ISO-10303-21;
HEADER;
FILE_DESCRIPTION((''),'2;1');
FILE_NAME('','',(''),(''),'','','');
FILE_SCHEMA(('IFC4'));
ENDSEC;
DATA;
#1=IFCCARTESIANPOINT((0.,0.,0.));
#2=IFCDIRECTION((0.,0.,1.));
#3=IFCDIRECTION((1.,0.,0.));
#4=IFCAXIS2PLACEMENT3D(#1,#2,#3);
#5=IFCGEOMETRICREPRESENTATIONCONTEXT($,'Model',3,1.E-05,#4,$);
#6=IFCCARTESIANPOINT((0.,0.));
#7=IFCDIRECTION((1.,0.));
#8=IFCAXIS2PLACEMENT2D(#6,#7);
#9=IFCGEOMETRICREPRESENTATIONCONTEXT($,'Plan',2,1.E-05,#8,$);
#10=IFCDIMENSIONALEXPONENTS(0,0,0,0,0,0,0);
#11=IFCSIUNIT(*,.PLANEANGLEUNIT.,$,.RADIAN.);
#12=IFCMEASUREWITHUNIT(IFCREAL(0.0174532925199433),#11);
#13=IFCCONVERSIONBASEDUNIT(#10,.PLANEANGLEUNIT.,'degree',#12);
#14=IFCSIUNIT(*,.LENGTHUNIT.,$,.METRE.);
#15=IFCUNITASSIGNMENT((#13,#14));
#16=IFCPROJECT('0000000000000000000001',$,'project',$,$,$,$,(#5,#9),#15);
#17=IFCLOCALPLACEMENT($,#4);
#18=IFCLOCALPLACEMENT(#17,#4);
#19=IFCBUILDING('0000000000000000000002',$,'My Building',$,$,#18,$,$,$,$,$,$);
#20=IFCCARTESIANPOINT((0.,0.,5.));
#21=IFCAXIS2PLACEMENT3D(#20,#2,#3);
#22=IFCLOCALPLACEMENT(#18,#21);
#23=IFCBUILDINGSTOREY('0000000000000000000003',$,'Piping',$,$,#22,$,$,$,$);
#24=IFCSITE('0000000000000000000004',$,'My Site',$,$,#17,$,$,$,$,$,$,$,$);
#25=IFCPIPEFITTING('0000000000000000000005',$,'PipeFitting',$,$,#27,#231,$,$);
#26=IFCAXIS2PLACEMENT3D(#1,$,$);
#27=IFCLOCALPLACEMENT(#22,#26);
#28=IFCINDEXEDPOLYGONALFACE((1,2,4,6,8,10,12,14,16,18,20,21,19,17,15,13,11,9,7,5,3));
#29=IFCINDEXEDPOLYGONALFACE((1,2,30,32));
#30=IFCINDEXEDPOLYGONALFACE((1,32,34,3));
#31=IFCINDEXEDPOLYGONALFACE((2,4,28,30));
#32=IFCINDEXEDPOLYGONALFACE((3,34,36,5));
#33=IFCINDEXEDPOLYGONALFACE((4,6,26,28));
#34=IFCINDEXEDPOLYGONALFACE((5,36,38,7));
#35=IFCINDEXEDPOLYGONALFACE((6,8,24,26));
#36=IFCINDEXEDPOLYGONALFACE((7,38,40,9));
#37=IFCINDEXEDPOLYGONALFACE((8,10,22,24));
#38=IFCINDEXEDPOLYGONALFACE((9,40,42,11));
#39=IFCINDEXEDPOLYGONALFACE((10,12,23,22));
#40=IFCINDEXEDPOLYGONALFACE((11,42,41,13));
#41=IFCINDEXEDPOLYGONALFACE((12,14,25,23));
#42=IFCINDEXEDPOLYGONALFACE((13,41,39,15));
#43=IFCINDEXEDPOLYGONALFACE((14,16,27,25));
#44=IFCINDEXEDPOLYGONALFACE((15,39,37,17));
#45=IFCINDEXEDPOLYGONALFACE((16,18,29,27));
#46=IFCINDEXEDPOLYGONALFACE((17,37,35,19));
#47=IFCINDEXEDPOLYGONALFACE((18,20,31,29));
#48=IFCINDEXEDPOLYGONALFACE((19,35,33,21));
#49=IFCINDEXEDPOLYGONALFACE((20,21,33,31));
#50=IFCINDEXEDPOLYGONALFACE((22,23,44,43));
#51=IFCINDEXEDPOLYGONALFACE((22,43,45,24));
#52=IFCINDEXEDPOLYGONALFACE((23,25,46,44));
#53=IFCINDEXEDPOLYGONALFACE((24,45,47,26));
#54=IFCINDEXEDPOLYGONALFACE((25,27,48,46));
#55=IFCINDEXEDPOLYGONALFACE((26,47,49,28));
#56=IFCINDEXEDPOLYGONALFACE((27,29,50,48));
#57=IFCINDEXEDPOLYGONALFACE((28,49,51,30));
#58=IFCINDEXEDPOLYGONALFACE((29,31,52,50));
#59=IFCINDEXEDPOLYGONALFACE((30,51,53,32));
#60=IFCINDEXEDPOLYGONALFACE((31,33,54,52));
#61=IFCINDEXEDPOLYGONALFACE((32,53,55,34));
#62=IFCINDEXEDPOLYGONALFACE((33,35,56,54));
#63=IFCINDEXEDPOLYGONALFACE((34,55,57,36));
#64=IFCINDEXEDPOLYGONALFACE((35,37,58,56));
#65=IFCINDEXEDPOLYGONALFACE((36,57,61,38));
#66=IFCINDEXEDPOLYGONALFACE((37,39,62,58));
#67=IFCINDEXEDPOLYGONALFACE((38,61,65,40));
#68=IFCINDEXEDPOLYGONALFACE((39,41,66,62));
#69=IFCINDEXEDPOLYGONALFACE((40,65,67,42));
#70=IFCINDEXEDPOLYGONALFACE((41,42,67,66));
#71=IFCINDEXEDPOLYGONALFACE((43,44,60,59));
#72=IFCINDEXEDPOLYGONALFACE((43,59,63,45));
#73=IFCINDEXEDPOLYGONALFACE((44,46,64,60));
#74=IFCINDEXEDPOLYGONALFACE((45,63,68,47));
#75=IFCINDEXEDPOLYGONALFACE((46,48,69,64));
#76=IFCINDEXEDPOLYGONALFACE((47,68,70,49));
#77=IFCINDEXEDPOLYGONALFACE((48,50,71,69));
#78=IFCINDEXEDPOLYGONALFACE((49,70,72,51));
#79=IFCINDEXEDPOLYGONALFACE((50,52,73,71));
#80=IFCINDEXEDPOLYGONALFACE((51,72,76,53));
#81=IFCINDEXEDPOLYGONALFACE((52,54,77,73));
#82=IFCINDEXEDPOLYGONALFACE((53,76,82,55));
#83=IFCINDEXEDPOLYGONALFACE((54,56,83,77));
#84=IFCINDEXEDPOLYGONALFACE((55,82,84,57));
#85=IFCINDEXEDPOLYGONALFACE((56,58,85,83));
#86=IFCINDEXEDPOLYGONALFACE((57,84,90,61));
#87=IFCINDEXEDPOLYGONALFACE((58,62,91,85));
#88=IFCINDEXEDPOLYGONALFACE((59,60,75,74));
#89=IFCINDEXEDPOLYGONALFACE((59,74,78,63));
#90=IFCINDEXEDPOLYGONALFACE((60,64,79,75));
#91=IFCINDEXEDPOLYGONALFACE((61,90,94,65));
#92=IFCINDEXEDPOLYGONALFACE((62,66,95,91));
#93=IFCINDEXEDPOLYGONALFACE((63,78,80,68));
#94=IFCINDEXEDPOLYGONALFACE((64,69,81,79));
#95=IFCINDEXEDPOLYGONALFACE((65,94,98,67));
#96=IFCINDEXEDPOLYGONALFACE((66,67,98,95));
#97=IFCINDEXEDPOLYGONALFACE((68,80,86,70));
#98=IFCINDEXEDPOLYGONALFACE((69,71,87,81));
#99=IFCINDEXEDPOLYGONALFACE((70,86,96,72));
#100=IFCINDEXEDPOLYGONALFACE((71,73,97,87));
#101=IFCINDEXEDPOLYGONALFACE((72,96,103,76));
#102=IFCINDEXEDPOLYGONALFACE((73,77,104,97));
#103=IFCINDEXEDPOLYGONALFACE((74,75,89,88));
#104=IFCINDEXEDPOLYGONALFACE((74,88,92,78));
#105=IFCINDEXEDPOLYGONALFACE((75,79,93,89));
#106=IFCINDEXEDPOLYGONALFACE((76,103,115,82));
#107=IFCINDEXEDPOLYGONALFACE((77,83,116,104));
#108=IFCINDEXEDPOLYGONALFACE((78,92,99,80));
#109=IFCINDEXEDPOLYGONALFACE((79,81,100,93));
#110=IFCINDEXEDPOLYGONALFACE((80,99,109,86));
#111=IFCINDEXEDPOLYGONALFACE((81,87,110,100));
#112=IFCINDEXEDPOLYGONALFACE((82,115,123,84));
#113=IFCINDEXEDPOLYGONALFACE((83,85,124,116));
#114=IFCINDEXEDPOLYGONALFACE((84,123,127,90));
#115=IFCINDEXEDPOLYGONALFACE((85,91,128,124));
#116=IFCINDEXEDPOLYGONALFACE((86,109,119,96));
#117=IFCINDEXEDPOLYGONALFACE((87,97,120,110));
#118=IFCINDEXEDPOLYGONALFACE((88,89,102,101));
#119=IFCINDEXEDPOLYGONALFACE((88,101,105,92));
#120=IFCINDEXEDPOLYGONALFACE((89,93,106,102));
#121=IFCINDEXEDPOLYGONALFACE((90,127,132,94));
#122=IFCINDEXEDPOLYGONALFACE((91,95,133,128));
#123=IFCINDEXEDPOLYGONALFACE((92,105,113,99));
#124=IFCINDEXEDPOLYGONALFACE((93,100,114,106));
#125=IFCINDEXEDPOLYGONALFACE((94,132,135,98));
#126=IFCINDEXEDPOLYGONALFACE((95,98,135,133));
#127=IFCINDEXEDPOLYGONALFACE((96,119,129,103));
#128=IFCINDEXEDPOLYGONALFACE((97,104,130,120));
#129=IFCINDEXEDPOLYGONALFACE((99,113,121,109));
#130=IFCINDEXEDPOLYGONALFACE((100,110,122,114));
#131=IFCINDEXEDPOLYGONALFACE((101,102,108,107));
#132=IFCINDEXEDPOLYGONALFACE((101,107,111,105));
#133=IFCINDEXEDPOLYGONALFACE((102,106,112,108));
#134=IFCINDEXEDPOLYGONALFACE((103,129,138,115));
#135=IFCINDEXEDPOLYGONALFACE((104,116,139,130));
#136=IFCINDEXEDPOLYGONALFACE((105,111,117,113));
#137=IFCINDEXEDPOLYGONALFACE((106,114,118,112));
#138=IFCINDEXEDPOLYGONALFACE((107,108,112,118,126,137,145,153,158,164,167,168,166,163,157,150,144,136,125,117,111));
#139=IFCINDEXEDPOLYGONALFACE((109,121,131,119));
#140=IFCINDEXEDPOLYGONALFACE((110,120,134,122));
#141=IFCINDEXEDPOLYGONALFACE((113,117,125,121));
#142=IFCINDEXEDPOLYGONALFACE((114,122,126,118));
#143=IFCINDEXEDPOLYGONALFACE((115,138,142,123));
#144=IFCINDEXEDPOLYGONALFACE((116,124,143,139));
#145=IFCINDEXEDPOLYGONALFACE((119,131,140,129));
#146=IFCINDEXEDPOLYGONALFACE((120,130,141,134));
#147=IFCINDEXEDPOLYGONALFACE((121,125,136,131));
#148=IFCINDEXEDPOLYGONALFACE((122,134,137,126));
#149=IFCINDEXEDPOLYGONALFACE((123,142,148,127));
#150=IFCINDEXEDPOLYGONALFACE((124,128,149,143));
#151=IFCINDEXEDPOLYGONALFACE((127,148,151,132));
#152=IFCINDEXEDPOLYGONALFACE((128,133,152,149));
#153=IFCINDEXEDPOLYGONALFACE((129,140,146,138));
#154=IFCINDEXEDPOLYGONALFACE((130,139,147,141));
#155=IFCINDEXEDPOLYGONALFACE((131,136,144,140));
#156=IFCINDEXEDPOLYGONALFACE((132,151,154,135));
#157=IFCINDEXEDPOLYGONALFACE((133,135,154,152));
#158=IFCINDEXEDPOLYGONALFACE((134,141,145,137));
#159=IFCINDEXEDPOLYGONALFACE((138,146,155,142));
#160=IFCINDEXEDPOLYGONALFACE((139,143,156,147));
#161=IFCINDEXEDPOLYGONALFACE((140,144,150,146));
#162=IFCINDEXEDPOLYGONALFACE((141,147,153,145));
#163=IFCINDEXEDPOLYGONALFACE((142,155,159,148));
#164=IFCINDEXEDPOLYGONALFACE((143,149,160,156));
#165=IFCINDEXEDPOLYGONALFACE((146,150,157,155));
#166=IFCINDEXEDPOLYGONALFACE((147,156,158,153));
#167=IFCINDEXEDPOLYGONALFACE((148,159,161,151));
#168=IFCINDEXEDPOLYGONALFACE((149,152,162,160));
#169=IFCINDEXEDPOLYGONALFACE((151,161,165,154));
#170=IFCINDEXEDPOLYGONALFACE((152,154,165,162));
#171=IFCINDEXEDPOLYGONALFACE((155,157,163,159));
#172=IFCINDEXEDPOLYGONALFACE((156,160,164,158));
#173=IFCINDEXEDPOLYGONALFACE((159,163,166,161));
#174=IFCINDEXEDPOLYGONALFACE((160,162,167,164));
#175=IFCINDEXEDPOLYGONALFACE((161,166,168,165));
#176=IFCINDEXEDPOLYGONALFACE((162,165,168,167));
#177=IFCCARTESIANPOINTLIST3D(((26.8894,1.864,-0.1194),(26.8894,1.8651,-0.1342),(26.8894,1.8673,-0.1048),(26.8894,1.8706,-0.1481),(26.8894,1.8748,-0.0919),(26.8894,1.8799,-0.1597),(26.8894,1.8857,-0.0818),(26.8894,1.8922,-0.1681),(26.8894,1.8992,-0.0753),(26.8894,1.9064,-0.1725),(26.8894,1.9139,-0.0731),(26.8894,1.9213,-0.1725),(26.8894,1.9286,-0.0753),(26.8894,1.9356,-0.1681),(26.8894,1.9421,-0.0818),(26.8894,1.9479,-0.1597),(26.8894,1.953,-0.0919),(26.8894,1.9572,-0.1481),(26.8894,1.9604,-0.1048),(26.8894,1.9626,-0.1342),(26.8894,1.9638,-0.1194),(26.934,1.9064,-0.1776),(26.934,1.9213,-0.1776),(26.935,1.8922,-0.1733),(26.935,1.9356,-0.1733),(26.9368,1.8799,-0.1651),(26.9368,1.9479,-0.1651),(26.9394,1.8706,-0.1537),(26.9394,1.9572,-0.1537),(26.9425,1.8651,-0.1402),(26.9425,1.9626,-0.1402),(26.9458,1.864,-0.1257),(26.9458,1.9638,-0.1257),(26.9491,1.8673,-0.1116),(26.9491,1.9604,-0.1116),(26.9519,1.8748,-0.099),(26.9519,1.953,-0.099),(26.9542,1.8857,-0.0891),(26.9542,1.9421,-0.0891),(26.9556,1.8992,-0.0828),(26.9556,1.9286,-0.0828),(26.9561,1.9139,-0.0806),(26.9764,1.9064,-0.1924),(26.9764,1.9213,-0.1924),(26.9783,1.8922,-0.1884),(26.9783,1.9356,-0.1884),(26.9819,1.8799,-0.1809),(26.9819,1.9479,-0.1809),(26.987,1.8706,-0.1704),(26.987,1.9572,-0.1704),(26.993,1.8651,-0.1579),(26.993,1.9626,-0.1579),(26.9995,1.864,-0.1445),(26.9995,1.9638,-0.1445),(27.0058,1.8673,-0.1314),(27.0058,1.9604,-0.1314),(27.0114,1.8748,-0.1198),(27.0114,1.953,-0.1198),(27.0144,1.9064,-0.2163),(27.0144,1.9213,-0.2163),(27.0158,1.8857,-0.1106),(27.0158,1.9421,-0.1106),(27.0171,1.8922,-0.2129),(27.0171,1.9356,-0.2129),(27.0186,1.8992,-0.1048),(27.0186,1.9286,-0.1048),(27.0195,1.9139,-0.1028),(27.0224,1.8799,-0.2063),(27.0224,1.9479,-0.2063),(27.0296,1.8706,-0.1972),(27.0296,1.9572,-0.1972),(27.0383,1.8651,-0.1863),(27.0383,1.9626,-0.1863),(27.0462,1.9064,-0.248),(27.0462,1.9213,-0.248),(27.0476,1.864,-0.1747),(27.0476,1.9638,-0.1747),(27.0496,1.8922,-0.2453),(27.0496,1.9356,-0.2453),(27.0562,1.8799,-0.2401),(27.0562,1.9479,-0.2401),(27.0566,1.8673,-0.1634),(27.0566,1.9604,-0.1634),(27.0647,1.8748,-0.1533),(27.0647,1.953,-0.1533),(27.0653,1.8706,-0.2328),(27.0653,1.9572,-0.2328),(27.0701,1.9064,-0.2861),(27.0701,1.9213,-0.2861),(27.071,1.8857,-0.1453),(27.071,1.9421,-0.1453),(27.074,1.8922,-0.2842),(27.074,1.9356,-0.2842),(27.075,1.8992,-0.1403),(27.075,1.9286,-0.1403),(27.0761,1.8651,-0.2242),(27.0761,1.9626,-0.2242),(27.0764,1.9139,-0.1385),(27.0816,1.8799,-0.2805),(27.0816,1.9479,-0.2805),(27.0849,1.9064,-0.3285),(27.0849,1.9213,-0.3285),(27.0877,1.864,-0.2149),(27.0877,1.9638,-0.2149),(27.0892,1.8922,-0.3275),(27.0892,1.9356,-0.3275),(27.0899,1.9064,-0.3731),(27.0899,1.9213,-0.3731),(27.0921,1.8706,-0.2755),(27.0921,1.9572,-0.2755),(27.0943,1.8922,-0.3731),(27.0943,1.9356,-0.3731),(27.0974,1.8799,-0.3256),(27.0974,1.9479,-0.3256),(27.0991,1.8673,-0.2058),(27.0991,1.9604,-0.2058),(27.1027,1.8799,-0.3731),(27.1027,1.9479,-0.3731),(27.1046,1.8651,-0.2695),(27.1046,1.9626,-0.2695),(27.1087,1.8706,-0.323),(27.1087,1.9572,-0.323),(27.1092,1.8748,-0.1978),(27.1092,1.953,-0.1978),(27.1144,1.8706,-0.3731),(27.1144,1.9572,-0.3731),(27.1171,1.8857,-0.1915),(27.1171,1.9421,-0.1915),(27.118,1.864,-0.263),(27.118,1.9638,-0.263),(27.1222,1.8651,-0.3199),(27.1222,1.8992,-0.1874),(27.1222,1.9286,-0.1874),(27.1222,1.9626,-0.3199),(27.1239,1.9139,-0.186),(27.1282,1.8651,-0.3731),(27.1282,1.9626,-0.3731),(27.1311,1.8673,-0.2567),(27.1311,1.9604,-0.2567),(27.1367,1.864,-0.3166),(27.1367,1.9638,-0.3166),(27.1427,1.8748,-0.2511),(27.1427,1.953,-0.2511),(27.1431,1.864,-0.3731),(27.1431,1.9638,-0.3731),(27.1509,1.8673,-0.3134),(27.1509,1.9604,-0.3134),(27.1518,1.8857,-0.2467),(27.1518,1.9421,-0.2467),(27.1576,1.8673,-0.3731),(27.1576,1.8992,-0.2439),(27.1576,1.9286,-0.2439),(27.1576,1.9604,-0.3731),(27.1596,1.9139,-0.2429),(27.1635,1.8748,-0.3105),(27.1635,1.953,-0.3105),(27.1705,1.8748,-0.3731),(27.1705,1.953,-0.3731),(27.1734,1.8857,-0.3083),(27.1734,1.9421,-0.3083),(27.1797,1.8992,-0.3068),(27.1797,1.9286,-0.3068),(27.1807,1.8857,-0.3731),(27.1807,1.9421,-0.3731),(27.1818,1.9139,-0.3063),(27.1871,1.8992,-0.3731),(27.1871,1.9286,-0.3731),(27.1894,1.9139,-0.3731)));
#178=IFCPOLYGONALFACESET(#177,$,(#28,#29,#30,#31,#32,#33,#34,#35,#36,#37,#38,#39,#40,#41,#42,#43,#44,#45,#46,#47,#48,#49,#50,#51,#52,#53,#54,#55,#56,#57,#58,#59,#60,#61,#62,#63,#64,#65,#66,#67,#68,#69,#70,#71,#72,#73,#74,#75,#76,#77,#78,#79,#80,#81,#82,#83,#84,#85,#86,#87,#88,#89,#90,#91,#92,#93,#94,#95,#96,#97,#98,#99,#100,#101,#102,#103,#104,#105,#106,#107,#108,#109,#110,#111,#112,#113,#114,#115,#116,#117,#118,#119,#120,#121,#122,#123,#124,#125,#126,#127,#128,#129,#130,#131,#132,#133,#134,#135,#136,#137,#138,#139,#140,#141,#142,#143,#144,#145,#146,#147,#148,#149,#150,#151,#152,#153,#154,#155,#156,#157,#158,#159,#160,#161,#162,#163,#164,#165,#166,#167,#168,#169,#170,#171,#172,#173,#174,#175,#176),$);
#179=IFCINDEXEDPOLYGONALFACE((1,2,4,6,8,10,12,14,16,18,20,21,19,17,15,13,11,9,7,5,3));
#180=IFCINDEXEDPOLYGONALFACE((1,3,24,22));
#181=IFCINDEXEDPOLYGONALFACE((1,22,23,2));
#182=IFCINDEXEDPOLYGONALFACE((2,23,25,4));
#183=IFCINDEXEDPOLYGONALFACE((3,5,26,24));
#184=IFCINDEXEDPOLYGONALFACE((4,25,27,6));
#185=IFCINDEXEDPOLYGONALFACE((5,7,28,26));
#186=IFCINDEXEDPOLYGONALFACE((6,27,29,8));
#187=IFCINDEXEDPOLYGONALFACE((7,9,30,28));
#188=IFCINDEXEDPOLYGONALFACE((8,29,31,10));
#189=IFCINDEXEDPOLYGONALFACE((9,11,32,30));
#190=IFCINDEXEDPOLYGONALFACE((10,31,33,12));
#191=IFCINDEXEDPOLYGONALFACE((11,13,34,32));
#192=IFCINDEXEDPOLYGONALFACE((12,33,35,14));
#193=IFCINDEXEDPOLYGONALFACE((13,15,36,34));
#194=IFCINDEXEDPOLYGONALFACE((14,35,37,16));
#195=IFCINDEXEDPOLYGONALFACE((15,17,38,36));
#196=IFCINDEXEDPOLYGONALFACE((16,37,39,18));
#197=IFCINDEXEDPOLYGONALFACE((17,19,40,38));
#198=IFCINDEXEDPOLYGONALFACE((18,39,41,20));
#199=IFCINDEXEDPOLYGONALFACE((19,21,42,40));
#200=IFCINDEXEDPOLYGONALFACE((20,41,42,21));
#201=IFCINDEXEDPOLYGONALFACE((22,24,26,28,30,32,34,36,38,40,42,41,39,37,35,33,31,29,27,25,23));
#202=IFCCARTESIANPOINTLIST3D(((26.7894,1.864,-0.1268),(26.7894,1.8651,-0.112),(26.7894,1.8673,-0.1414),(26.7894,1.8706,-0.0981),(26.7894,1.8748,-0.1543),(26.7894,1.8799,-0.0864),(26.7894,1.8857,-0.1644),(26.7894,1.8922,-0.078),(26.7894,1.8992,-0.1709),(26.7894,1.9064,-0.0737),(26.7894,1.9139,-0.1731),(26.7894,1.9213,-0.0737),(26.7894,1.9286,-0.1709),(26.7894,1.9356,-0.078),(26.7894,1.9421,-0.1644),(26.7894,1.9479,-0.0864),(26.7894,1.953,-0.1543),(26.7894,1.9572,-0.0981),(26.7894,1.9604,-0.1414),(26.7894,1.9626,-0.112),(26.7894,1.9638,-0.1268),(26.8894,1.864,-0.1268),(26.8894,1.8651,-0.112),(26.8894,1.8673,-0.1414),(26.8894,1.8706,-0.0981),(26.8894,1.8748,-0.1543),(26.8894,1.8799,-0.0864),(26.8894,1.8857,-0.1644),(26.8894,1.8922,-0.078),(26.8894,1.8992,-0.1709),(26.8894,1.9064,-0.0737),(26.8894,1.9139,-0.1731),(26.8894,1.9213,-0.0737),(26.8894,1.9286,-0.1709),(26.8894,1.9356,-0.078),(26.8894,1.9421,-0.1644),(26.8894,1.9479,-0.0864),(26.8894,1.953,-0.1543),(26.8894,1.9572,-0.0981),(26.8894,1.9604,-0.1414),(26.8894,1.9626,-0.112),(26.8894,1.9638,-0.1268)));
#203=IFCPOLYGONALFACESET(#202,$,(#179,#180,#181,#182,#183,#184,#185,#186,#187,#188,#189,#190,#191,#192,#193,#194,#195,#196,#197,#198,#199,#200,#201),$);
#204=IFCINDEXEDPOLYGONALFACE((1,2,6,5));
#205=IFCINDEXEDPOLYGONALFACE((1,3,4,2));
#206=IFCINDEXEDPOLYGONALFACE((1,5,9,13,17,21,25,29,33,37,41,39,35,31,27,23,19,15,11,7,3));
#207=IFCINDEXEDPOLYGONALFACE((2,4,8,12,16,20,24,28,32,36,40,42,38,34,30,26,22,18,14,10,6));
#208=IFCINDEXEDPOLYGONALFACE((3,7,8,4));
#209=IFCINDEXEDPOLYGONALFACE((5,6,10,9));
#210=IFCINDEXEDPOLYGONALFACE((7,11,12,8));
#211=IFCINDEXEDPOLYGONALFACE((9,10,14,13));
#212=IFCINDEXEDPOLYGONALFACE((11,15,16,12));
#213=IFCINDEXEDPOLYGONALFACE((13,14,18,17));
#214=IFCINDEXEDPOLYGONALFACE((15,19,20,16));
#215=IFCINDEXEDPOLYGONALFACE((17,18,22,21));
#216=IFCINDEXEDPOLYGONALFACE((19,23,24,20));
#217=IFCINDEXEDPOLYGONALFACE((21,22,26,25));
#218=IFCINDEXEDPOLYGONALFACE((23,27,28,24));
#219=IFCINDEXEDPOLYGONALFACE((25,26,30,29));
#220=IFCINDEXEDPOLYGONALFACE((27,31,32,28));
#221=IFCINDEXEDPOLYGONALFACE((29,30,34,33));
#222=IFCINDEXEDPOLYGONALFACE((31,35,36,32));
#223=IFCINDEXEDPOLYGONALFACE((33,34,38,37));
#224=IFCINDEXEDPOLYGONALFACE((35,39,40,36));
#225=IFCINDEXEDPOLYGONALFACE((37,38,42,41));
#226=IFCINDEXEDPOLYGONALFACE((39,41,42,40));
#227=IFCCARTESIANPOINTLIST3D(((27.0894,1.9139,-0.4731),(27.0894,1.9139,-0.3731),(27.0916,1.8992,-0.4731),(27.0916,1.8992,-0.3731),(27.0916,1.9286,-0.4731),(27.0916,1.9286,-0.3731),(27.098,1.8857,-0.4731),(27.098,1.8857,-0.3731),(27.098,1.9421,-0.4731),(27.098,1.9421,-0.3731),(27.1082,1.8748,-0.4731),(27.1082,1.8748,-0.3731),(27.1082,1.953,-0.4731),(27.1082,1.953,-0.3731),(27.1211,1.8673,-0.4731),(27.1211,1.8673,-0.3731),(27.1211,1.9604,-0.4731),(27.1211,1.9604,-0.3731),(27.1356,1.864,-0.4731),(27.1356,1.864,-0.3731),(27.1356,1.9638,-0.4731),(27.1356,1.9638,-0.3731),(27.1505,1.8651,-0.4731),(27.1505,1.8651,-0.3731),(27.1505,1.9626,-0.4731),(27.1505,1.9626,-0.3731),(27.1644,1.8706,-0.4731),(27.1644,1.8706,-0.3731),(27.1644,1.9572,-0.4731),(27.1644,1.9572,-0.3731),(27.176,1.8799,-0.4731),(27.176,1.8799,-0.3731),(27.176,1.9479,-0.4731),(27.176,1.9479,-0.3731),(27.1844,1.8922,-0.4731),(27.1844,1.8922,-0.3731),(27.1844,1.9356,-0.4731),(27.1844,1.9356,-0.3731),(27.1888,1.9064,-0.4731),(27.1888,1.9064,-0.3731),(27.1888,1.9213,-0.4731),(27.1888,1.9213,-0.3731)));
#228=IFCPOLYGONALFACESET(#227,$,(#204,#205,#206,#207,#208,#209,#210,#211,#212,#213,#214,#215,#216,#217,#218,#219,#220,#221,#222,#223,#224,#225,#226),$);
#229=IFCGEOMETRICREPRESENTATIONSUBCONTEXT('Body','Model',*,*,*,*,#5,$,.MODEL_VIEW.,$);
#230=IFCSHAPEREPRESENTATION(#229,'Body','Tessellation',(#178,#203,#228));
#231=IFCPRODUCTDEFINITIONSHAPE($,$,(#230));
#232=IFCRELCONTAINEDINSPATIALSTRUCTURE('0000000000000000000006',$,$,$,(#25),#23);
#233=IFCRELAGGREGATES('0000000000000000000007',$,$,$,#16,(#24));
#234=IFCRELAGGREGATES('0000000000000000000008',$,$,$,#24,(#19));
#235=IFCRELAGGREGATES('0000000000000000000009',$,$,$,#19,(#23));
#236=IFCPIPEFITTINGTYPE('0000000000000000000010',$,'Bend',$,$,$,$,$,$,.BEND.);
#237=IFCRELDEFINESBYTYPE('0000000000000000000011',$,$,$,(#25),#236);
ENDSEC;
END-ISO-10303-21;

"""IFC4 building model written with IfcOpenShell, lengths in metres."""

from ifc_helpers import new_model, entity, si_unit, converted_unit, frame, origin_with_axes, origin_2d_with_axis, place, context, subcontext, project, spatial, circle, extrude, source, transform, mapped, type_object, type_shapes, element, save


model = new_model("IFC4")

# Units and contexts
model_context = context("Model", 3, precision=1e-05, world=origin_with_axes())
plan_context = context("Plan", 2, precision=1e-05, world=origin_2d_with_axis())
body_context = subcontext(model_context, "Body", "Model", "MODEL_VIEW")
ifc_project = project(units=[converted_unit("PLANEANGLEUNIT", "degree", entity("IfcReal", 0.0174532925199433), si_unit("PLANEANGLEUNIT", "RADIAN"), dimensions=[0, 0, 0, 0, 0, 0, 0]), si_unit("LENGTHUNIT", "METRE")], contexts=[model_context, plan_context])

# Site, building, storey
site_placement = place(None, origin_with_axes())
site = spatial("IfcSite", under=ifc_project, at=site_placement, Name="My Site")
building_placement = place(site_placement, origin_with_axes())
building = spatial("IfcBuilding", under=site, at=building_placement, Name="My Building")
storey_placement = place(building_placement, frame((0.0, 0.0, 5.0), z_axis=(0.0, 0.0, 1.0), x_axis=(1.0, 0.0, 0.0)))
storey = spatial("IfcBuildingStorey", under=building, at=storey_placement, Name="Piping")

# Pipe fitting
pipe_fitting_type_1 = type_object("IfcPipeFittingType", Name="Bend", PredefinedType="BEND")
shared_shape = source(origin_with_axes(), body_context, "Body", "SolidModel", [
    entity("IfcSweptDiskSolid", entity("IfcIndexedPolyCurve", entity("IfcCartesianPointList3D", [[0.0, 0.0, -0.1], [0.0732, 0.0, -0.2768], [0.25, 0.0, -0.35]]), [entity("IfcArcIndex", [1, 2, 3])]), 0.05),
    extrude(circle(Radius=0.05), origin_with_axes(), (0.0, 0.0, -1.0), 0.1),
    extrude(circle(Radius=0.05), frame((0.25, 0.0, -0.35), z_axis=(1.0, 0.0, 0.0), x_axis=(0.0, 0.0, 1.0)), (0.0, 0.0, 1.0), 0.1),
])
type_shapes(pipe_fitting_type_1, [shared_shape])
for number, where, z_axis, x_axis, name in (
    (1, (26.7894, 1.9139, -0.1231), (-1.0, -0.000001, 0.0), (0.0, 0.0, -1.0), "PipeFitting"),
):
    element("IfcPipeFitting", number, at=place(storey_placement, frame(where, z_axis=z_axis, x_axis=x_axis)), inside=storey, type_object=pipe_fitting_type_1, Name=name, context=body_context, shape_type="MappedRepresentation", body=[
        mapped(shared_shape, transform((0.0, 0.0, 0.0), x_axis=(1.0, 0.0, 0.0), y_axis=(0.0, 1.0, 0.0), z_axis=(0.0, 0.0, 1.0), scale=1.0)),
    ])

save(model, "model.ifc")
